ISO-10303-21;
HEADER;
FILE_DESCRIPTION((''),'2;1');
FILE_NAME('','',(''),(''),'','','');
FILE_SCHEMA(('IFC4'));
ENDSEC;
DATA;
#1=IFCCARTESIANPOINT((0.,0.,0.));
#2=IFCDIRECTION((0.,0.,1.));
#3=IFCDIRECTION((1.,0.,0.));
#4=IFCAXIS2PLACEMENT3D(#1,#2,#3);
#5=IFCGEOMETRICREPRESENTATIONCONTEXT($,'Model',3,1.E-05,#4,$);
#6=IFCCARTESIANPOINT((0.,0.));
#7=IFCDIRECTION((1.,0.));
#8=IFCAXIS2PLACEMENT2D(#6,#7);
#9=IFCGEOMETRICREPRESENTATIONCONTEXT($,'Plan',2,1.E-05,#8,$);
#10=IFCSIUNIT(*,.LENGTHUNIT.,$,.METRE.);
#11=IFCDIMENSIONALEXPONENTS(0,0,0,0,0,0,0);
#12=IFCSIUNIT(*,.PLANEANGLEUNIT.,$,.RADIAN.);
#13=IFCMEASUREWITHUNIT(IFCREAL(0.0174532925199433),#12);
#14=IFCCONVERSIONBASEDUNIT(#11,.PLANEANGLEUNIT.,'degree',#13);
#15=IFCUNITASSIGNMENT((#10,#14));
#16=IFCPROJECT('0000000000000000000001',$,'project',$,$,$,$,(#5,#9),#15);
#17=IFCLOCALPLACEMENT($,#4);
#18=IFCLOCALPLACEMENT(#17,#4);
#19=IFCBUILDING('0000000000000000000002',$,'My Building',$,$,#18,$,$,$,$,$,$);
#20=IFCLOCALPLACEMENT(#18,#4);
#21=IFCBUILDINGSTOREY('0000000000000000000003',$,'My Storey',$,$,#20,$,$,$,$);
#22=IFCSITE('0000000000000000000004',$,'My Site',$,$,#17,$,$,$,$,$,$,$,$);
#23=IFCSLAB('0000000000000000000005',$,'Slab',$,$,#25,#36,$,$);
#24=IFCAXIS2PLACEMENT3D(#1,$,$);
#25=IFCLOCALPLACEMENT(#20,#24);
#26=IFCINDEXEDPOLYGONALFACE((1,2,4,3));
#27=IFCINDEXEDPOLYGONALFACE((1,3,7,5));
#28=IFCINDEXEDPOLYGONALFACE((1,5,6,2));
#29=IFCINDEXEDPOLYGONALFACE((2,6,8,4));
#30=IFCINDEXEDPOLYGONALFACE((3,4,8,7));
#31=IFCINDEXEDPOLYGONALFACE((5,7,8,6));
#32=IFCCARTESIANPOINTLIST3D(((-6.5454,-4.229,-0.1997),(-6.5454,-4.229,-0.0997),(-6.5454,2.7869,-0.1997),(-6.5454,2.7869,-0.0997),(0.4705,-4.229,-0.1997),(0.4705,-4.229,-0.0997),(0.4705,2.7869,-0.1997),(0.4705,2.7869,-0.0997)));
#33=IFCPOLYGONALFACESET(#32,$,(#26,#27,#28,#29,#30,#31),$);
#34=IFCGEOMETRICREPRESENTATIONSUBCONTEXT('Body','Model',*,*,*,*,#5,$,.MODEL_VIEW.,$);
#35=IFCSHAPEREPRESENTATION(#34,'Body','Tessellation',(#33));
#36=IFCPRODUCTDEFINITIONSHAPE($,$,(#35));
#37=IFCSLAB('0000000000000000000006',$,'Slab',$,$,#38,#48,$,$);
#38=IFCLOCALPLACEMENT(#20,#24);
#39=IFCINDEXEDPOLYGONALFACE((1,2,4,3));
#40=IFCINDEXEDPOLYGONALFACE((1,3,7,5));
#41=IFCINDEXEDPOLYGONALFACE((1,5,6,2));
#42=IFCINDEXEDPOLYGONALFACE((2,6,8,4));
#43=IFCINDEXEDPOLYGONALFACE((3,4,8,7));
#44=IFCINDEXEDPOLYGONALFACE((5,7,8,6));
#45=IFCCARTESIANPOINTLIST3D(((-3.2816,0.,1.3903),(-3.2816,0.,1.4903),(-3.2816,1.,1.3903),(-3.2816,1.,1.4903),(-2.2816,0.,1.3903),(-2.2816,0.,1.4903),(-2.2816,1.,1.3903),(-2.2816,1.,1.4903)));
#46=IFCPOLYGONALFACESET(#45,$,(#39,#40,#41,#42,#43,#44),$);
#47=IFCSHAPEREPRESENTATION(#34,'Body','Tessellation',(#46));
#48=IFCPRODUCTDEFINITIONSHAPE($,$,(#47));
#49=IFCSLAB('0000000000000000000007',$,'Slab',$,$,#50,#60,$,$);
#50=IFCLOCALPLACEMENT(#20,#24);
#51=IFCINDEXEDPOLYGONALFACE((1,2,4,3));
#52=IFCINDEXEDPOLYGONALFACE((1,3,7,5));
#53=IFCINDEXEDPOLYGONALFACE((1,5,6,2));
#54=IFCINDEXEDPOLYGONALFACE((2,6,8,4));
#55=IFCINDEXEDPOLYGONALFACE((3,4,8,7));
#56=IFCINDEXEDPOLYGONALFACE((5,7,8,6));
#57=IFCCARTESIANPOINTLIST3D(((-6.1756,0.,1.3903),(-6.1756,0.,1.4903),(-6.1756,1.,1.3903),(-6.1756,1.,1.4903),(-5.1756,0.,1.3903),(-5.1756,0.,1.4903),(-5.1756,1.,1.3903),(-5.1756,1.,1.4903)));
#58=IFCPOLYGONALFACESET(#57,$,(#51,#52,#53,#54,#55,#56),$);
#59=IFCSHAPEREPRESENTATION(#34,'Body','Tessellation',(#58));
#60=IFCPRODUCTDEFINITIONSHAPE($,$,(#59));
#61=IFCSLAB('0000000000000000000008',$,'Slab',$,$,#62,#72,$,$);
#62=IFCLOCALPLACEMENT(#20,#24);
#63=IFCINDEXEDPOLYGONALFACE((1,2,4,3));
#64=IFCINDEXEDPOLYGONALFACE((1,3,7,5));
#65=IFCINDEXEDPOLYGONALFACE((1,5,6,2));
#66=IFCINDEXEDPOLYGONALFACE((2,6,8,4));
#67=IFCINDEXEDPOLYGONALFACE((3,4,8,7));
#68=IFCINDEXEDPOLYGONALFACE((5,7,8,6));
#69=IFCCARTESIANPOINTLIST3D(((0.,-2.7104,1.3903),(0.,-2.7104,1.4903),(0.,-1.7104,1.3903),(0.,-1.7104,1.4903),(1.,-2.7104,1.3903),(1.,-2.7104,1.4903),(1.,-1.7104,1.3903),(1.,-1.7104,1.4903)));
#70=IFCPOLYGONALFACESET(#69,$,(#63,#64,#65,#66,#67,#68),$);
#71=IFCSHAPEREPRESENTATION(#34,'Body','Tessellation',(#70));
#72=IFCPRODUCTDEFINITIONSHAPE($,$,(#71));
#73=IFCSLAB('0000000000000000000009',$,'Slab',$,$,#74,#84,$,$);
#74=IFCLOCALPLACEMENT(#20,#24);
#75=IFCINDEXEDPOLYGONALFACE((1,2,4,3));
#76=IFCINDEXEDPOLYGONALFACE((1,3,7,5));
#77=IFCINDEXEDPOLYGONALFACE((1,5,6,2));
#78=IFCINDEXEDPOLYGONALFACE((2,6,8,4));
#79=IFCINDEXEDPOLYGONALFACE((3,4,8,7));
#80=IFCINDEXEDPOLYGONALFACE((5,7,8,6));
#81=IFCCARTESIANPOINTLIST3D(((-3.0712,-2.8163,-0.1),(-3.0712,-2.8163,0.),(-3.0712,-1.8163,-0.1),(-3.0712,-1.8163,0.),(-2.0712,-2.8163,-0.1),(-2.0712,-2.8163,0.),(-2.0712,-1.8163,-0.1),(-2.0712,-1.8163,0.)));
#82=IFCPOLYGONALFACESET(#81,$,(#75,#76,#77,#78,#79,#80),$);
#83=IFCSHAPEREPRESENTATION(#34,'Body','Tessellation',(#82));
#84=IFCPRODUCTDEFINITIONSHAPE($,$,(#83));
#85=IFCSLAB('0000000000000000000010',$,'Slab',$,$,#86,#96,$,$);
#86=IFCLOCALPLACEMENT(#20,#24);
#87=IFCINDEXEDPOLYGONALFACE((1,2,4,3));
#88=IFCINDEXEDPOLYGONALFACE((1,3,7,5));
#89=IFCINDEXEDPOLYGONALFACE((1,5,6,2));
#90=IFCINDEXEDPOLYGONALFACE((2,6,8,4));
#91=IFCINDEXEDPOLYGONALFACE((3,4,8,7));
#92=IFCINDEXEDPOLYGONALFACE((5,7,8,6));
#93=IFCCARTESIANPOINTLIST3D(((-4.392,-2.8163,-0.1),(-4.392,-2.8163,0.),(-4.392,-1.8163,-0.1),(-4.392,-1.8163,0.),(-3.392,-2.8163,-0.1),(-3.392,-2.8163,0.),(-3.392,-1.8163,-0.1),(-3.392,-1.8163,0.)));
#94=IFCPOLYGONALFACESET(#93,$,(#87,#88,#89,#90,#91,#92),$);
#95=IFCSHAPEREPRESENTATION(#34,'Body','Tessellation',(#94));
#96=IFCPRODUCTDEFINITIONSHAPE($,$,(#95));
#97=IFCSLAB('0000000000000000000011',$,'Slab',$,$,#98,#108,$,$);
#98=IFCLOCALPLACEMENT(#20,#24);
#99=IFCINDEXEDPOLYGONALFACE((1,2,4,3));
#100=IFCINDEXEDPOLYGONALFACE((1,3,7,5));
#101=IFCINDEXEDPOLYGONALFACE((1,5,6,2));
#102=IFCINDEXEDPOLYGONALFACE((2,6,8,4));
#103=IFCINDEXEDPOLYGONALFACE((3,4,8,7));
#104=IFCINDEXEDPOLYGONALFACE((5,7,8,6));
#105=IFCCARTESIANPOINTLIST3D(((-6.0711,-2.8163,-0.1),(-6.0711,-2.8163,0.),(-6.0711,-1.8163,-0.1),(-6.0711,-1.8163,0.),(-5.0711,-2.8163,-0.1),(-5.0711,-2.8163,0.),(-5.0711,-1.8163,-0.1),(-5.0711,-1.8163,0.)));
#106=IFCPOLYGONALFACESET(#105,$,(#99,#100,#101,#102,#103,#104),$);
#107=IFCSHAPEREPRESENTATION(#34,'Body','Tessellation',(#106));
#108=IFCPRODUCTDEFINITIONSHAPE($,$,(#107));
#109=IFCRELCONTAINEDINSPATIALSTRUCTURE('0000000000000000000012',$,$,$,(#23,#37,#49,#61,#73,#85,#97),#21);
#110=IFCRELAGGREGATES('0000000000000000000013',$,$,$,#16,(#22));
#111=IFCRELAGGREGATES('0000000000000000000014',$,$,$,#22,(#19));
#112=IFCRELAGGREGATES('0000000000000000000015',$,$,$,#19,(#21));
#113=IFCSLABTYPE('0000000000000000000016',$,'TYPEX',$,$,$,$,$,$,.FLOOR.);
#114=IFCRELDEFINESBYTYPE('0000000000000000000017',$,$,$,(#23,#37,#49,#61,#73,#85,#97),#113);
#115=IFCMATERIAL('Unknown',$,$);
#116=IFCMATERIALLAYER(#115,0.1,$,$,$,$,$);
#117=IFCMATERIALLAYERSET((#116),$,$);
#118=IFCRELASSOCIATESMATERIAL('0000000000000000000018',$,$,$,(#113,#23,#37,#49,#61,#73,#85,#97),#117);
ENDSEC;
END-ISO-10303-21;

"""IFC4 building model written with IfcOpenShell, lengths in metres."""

from ifc_helpers import new_model, entity, si_unit, converted_unit, frame, origin_with_axes, origin_2d_with_axis, place, context, subcontext, project, spatial, line, indexed_curve, outline, extrude, material, layer, layer_set, layer_usage, type_object, element, save


model = new_model("IFC4")

# Units and contexts
model_context = context("Model", 3, precision=1e-05, world=origin_with_axes())
plan_context = context("Plan", 2, precision=1e-05, world=origin_2d_with_axis())
body_context = subcontext(model_context, "Body", "Model", "MODEL_VIEW")
ifc_project = project(units=[si_unit("LENGTHUNIT", "METRE"), converted_unit("PLANEANGLEUNIT", "degree", entity("IfcReal", 0.0174532925199433), si_unit("PLANEANGLEUNIT", "RADIAN"), dimensions=[0, 0, 0, 0, 0, 0, 0])], contexts=[model_context, plan_context])

# Site, building, storey
site_placement = place(None, origin_with_axes())
site = spatial("IfcSite", under=ifc_project, at=site_placement, Name="My Site")
building_placement = place(site_placement, origin_with_axes())
building = spatial("IfcBuilding", under=site, at=building_placement, Name="My Building")
storey_placement = place(building_placement, origin_with_axes())
storey = spatial("IfcBuildingStorey", under=building, at=storey_placement, Name="My Storey")

# Slabs
ifc_material = material(Name="Unknown")
ifc_layer = layer(ifc_material, 0.1)
ifc_layer_set = layer_set([ifc_layer])
ifc_layer_usage_1 = layer_usage(ifc_layer_set, "AXIS3", "POSITIVE", 0.0)
slab_type = type_object("IfcSlabType", Name="TYPEX", PredefinedType="FLOOR", material=ifc_layer_set)
slab_1_placement = place(storey_placement, frame((0.0, 0.0, -0.1997), z_axis=(0.0, 0.0, 1.0), x_axis=(1.0, 0.0, 0.0)))
element("IfcSlab", 1, at=slab_1_placement, inside=storey, type_object=slab_type, material=ifc_layer_usage_1, Name="Slab", context=body_context, shape_type="SweptSolid", body=[
    extrude(outline(indexed_curve([(-6.5454, -4.229), (-6.5454, 2.7869), (0.4705, 2.7869), (0.4705, -4.229)], segments=[line(3, 4), line(4, 1), line(1, 2), line(2, 3)], self_intersect=False)), None, (0.0, 0.0, 1.0), 0.1),
])
ifc_layer_usage_2 = layer_usage(ifc_layer_set, "AXIS3", "POSITIVE", 0.0)
slab_2_placement = place(storey_placement, frame((-3.2816, 0.0, 1.3903), z_axis=(0.0, 0.0, 1.0), x_axis=(1.0, 0.0, 0.0)))
element("IfcSlab", 2, at=slab_2_placement, inside=storey, type_object=slab_type, material=ifc_layer_usage_2, Name="Slab", context=body_context, shape_type="SweptSolid", body=[
    extrude(outline(indexed_curve([(0.0, 0.0), (1.0, 0.0), (1.0, 1.0), (0.0, 1.0), (0.0, 0.0)])), None, (0.0, 0.0, 1.0), 0.1),
])
ifc_layer_usage_3 = layer_usage(ifc_layer_set, "AXIS3", "POSITIVE", 0.0)
slab_3_placement = place(storey_placement, frame((-6.1756, 0.0, 1.3903), z_axis=(0.0, 0.0, 1.0), x_axis=(1.0, 0.0, 0.0)))
element("IfcSlab", 3, at=slab_3_placement, inside=storey, type_object=slab_type, material=ifc_layer_usage_3, Name="Slab", context=body_context, shape_type="SweptSolid", body=[
    extrude(outline(indexed_curve([(0.0, 0.0), (1.0, 0.0), (1.0, 1.0), (0.0, 1.0), (0.0, 0.0)])), None, (0.0, 0.0, 1.0), 0.1),
])
ifc_layer_usage_4 = layer_usage(ifc_layer_set, "AXIS3", "POSITIVE", 0.0)
slab_4_placement = place(storey_placement, frame((0.0, -2.7104, 1.3903), z_axis=(0.0, 0.0, 1.0), x_axis=(1.0, 0.0, 0.0)))
element("IfcSlab", 4, at=slab_4_placement, inside=storey, type_object=slab_type, material=ifc_layer_usage_4, Name="Slab", context=body_context, shape_type="SweptSolid", body=[
    extrude(outline(indexed_curve([(0.0, 0.0), (1.0, 0.0), (1.0, 1.0), (0.0, 1.0), (0.0, 0.0)])), None, (0.0, 0.0, 1.0), 0.1),
])
ifc_layer_usage_5 = layer_usage(ifc_layer_set, "AXIS3", "POSITIVE", 0.0)
slab_5_placement = place(storey_placement, frame((-3.0712, -2.8163, -0.1), z_axis=(0.0, 0.0, 1.0), x_axis=(1.0, 0.0, 0.0)))
element("IfcSlab", 5, at=slab_5_placement, inside=storey, type_object=slab_type, material=ifc_layer_usage_5, Name="Slab", context=body_context, shape_type="SweptSolid", body=[
    extrude(outline(indexed_curve([(0.0, 0.0), (1.0, 0.0), (1.0, 1.0), (0.0, 1.0), (0.0, 0.0)])), None, (0.0, 0.0, 1.0), 0.1),
])
ifc_layer_usage_6 = layer_usage(ifc_layer_set, "AXIS3", "POSITIVE", 0.0)
slab_6_placement = place(storey_placement, frame((-4.392, -2.8163, -0.1), z_axis=(0.0, 0.0, 1.0), x_axis=(1.0, 0.0, 0.0)))
element("IfcSlab", 6, at=slab_6_placement, inside=storey, type_object=slab_type, material=ifc_layer_usage_6, Name="Slab", context=body_context, shape_type="SweptSolid", body=[
    extrude(outline(indexed_curve([(0.0, 0.0), (1.0, 0.0), (1.0, 1.0), (0.0, 1.0), (0.0, 0.0)])), None, (0.0, 0.0, 1.0), 0.1),
])
ifc_layer_usage_7 = layer_usage(ifc_layer_set, "AXIS3", "POSITIVE", 0.0)
slab_7_placement = place(storey_placement, frame((-6.0711, -2.8163, -0.1), z_axis=(0.0, 0.0, 1.0), x_axis=(1.0, 0.0, 0.0)))
element("IfcSlab", 7, at=slab_7_placement, inside=storey, type_object=slab_type, material=ifc_layer_usage_7, Name="Slab", context=body_context, shape_type="SweptSolid", body=[
    extrude(outline(indexed_curve([(0.0, 0.0), (1.0, 0.0), (1.0, 1.0), (0.0, 1.0), (0.0, 0.0)])), None, (0.0, 0.0, 1.0), 0.1),
])

save(model, "model.ifc")
